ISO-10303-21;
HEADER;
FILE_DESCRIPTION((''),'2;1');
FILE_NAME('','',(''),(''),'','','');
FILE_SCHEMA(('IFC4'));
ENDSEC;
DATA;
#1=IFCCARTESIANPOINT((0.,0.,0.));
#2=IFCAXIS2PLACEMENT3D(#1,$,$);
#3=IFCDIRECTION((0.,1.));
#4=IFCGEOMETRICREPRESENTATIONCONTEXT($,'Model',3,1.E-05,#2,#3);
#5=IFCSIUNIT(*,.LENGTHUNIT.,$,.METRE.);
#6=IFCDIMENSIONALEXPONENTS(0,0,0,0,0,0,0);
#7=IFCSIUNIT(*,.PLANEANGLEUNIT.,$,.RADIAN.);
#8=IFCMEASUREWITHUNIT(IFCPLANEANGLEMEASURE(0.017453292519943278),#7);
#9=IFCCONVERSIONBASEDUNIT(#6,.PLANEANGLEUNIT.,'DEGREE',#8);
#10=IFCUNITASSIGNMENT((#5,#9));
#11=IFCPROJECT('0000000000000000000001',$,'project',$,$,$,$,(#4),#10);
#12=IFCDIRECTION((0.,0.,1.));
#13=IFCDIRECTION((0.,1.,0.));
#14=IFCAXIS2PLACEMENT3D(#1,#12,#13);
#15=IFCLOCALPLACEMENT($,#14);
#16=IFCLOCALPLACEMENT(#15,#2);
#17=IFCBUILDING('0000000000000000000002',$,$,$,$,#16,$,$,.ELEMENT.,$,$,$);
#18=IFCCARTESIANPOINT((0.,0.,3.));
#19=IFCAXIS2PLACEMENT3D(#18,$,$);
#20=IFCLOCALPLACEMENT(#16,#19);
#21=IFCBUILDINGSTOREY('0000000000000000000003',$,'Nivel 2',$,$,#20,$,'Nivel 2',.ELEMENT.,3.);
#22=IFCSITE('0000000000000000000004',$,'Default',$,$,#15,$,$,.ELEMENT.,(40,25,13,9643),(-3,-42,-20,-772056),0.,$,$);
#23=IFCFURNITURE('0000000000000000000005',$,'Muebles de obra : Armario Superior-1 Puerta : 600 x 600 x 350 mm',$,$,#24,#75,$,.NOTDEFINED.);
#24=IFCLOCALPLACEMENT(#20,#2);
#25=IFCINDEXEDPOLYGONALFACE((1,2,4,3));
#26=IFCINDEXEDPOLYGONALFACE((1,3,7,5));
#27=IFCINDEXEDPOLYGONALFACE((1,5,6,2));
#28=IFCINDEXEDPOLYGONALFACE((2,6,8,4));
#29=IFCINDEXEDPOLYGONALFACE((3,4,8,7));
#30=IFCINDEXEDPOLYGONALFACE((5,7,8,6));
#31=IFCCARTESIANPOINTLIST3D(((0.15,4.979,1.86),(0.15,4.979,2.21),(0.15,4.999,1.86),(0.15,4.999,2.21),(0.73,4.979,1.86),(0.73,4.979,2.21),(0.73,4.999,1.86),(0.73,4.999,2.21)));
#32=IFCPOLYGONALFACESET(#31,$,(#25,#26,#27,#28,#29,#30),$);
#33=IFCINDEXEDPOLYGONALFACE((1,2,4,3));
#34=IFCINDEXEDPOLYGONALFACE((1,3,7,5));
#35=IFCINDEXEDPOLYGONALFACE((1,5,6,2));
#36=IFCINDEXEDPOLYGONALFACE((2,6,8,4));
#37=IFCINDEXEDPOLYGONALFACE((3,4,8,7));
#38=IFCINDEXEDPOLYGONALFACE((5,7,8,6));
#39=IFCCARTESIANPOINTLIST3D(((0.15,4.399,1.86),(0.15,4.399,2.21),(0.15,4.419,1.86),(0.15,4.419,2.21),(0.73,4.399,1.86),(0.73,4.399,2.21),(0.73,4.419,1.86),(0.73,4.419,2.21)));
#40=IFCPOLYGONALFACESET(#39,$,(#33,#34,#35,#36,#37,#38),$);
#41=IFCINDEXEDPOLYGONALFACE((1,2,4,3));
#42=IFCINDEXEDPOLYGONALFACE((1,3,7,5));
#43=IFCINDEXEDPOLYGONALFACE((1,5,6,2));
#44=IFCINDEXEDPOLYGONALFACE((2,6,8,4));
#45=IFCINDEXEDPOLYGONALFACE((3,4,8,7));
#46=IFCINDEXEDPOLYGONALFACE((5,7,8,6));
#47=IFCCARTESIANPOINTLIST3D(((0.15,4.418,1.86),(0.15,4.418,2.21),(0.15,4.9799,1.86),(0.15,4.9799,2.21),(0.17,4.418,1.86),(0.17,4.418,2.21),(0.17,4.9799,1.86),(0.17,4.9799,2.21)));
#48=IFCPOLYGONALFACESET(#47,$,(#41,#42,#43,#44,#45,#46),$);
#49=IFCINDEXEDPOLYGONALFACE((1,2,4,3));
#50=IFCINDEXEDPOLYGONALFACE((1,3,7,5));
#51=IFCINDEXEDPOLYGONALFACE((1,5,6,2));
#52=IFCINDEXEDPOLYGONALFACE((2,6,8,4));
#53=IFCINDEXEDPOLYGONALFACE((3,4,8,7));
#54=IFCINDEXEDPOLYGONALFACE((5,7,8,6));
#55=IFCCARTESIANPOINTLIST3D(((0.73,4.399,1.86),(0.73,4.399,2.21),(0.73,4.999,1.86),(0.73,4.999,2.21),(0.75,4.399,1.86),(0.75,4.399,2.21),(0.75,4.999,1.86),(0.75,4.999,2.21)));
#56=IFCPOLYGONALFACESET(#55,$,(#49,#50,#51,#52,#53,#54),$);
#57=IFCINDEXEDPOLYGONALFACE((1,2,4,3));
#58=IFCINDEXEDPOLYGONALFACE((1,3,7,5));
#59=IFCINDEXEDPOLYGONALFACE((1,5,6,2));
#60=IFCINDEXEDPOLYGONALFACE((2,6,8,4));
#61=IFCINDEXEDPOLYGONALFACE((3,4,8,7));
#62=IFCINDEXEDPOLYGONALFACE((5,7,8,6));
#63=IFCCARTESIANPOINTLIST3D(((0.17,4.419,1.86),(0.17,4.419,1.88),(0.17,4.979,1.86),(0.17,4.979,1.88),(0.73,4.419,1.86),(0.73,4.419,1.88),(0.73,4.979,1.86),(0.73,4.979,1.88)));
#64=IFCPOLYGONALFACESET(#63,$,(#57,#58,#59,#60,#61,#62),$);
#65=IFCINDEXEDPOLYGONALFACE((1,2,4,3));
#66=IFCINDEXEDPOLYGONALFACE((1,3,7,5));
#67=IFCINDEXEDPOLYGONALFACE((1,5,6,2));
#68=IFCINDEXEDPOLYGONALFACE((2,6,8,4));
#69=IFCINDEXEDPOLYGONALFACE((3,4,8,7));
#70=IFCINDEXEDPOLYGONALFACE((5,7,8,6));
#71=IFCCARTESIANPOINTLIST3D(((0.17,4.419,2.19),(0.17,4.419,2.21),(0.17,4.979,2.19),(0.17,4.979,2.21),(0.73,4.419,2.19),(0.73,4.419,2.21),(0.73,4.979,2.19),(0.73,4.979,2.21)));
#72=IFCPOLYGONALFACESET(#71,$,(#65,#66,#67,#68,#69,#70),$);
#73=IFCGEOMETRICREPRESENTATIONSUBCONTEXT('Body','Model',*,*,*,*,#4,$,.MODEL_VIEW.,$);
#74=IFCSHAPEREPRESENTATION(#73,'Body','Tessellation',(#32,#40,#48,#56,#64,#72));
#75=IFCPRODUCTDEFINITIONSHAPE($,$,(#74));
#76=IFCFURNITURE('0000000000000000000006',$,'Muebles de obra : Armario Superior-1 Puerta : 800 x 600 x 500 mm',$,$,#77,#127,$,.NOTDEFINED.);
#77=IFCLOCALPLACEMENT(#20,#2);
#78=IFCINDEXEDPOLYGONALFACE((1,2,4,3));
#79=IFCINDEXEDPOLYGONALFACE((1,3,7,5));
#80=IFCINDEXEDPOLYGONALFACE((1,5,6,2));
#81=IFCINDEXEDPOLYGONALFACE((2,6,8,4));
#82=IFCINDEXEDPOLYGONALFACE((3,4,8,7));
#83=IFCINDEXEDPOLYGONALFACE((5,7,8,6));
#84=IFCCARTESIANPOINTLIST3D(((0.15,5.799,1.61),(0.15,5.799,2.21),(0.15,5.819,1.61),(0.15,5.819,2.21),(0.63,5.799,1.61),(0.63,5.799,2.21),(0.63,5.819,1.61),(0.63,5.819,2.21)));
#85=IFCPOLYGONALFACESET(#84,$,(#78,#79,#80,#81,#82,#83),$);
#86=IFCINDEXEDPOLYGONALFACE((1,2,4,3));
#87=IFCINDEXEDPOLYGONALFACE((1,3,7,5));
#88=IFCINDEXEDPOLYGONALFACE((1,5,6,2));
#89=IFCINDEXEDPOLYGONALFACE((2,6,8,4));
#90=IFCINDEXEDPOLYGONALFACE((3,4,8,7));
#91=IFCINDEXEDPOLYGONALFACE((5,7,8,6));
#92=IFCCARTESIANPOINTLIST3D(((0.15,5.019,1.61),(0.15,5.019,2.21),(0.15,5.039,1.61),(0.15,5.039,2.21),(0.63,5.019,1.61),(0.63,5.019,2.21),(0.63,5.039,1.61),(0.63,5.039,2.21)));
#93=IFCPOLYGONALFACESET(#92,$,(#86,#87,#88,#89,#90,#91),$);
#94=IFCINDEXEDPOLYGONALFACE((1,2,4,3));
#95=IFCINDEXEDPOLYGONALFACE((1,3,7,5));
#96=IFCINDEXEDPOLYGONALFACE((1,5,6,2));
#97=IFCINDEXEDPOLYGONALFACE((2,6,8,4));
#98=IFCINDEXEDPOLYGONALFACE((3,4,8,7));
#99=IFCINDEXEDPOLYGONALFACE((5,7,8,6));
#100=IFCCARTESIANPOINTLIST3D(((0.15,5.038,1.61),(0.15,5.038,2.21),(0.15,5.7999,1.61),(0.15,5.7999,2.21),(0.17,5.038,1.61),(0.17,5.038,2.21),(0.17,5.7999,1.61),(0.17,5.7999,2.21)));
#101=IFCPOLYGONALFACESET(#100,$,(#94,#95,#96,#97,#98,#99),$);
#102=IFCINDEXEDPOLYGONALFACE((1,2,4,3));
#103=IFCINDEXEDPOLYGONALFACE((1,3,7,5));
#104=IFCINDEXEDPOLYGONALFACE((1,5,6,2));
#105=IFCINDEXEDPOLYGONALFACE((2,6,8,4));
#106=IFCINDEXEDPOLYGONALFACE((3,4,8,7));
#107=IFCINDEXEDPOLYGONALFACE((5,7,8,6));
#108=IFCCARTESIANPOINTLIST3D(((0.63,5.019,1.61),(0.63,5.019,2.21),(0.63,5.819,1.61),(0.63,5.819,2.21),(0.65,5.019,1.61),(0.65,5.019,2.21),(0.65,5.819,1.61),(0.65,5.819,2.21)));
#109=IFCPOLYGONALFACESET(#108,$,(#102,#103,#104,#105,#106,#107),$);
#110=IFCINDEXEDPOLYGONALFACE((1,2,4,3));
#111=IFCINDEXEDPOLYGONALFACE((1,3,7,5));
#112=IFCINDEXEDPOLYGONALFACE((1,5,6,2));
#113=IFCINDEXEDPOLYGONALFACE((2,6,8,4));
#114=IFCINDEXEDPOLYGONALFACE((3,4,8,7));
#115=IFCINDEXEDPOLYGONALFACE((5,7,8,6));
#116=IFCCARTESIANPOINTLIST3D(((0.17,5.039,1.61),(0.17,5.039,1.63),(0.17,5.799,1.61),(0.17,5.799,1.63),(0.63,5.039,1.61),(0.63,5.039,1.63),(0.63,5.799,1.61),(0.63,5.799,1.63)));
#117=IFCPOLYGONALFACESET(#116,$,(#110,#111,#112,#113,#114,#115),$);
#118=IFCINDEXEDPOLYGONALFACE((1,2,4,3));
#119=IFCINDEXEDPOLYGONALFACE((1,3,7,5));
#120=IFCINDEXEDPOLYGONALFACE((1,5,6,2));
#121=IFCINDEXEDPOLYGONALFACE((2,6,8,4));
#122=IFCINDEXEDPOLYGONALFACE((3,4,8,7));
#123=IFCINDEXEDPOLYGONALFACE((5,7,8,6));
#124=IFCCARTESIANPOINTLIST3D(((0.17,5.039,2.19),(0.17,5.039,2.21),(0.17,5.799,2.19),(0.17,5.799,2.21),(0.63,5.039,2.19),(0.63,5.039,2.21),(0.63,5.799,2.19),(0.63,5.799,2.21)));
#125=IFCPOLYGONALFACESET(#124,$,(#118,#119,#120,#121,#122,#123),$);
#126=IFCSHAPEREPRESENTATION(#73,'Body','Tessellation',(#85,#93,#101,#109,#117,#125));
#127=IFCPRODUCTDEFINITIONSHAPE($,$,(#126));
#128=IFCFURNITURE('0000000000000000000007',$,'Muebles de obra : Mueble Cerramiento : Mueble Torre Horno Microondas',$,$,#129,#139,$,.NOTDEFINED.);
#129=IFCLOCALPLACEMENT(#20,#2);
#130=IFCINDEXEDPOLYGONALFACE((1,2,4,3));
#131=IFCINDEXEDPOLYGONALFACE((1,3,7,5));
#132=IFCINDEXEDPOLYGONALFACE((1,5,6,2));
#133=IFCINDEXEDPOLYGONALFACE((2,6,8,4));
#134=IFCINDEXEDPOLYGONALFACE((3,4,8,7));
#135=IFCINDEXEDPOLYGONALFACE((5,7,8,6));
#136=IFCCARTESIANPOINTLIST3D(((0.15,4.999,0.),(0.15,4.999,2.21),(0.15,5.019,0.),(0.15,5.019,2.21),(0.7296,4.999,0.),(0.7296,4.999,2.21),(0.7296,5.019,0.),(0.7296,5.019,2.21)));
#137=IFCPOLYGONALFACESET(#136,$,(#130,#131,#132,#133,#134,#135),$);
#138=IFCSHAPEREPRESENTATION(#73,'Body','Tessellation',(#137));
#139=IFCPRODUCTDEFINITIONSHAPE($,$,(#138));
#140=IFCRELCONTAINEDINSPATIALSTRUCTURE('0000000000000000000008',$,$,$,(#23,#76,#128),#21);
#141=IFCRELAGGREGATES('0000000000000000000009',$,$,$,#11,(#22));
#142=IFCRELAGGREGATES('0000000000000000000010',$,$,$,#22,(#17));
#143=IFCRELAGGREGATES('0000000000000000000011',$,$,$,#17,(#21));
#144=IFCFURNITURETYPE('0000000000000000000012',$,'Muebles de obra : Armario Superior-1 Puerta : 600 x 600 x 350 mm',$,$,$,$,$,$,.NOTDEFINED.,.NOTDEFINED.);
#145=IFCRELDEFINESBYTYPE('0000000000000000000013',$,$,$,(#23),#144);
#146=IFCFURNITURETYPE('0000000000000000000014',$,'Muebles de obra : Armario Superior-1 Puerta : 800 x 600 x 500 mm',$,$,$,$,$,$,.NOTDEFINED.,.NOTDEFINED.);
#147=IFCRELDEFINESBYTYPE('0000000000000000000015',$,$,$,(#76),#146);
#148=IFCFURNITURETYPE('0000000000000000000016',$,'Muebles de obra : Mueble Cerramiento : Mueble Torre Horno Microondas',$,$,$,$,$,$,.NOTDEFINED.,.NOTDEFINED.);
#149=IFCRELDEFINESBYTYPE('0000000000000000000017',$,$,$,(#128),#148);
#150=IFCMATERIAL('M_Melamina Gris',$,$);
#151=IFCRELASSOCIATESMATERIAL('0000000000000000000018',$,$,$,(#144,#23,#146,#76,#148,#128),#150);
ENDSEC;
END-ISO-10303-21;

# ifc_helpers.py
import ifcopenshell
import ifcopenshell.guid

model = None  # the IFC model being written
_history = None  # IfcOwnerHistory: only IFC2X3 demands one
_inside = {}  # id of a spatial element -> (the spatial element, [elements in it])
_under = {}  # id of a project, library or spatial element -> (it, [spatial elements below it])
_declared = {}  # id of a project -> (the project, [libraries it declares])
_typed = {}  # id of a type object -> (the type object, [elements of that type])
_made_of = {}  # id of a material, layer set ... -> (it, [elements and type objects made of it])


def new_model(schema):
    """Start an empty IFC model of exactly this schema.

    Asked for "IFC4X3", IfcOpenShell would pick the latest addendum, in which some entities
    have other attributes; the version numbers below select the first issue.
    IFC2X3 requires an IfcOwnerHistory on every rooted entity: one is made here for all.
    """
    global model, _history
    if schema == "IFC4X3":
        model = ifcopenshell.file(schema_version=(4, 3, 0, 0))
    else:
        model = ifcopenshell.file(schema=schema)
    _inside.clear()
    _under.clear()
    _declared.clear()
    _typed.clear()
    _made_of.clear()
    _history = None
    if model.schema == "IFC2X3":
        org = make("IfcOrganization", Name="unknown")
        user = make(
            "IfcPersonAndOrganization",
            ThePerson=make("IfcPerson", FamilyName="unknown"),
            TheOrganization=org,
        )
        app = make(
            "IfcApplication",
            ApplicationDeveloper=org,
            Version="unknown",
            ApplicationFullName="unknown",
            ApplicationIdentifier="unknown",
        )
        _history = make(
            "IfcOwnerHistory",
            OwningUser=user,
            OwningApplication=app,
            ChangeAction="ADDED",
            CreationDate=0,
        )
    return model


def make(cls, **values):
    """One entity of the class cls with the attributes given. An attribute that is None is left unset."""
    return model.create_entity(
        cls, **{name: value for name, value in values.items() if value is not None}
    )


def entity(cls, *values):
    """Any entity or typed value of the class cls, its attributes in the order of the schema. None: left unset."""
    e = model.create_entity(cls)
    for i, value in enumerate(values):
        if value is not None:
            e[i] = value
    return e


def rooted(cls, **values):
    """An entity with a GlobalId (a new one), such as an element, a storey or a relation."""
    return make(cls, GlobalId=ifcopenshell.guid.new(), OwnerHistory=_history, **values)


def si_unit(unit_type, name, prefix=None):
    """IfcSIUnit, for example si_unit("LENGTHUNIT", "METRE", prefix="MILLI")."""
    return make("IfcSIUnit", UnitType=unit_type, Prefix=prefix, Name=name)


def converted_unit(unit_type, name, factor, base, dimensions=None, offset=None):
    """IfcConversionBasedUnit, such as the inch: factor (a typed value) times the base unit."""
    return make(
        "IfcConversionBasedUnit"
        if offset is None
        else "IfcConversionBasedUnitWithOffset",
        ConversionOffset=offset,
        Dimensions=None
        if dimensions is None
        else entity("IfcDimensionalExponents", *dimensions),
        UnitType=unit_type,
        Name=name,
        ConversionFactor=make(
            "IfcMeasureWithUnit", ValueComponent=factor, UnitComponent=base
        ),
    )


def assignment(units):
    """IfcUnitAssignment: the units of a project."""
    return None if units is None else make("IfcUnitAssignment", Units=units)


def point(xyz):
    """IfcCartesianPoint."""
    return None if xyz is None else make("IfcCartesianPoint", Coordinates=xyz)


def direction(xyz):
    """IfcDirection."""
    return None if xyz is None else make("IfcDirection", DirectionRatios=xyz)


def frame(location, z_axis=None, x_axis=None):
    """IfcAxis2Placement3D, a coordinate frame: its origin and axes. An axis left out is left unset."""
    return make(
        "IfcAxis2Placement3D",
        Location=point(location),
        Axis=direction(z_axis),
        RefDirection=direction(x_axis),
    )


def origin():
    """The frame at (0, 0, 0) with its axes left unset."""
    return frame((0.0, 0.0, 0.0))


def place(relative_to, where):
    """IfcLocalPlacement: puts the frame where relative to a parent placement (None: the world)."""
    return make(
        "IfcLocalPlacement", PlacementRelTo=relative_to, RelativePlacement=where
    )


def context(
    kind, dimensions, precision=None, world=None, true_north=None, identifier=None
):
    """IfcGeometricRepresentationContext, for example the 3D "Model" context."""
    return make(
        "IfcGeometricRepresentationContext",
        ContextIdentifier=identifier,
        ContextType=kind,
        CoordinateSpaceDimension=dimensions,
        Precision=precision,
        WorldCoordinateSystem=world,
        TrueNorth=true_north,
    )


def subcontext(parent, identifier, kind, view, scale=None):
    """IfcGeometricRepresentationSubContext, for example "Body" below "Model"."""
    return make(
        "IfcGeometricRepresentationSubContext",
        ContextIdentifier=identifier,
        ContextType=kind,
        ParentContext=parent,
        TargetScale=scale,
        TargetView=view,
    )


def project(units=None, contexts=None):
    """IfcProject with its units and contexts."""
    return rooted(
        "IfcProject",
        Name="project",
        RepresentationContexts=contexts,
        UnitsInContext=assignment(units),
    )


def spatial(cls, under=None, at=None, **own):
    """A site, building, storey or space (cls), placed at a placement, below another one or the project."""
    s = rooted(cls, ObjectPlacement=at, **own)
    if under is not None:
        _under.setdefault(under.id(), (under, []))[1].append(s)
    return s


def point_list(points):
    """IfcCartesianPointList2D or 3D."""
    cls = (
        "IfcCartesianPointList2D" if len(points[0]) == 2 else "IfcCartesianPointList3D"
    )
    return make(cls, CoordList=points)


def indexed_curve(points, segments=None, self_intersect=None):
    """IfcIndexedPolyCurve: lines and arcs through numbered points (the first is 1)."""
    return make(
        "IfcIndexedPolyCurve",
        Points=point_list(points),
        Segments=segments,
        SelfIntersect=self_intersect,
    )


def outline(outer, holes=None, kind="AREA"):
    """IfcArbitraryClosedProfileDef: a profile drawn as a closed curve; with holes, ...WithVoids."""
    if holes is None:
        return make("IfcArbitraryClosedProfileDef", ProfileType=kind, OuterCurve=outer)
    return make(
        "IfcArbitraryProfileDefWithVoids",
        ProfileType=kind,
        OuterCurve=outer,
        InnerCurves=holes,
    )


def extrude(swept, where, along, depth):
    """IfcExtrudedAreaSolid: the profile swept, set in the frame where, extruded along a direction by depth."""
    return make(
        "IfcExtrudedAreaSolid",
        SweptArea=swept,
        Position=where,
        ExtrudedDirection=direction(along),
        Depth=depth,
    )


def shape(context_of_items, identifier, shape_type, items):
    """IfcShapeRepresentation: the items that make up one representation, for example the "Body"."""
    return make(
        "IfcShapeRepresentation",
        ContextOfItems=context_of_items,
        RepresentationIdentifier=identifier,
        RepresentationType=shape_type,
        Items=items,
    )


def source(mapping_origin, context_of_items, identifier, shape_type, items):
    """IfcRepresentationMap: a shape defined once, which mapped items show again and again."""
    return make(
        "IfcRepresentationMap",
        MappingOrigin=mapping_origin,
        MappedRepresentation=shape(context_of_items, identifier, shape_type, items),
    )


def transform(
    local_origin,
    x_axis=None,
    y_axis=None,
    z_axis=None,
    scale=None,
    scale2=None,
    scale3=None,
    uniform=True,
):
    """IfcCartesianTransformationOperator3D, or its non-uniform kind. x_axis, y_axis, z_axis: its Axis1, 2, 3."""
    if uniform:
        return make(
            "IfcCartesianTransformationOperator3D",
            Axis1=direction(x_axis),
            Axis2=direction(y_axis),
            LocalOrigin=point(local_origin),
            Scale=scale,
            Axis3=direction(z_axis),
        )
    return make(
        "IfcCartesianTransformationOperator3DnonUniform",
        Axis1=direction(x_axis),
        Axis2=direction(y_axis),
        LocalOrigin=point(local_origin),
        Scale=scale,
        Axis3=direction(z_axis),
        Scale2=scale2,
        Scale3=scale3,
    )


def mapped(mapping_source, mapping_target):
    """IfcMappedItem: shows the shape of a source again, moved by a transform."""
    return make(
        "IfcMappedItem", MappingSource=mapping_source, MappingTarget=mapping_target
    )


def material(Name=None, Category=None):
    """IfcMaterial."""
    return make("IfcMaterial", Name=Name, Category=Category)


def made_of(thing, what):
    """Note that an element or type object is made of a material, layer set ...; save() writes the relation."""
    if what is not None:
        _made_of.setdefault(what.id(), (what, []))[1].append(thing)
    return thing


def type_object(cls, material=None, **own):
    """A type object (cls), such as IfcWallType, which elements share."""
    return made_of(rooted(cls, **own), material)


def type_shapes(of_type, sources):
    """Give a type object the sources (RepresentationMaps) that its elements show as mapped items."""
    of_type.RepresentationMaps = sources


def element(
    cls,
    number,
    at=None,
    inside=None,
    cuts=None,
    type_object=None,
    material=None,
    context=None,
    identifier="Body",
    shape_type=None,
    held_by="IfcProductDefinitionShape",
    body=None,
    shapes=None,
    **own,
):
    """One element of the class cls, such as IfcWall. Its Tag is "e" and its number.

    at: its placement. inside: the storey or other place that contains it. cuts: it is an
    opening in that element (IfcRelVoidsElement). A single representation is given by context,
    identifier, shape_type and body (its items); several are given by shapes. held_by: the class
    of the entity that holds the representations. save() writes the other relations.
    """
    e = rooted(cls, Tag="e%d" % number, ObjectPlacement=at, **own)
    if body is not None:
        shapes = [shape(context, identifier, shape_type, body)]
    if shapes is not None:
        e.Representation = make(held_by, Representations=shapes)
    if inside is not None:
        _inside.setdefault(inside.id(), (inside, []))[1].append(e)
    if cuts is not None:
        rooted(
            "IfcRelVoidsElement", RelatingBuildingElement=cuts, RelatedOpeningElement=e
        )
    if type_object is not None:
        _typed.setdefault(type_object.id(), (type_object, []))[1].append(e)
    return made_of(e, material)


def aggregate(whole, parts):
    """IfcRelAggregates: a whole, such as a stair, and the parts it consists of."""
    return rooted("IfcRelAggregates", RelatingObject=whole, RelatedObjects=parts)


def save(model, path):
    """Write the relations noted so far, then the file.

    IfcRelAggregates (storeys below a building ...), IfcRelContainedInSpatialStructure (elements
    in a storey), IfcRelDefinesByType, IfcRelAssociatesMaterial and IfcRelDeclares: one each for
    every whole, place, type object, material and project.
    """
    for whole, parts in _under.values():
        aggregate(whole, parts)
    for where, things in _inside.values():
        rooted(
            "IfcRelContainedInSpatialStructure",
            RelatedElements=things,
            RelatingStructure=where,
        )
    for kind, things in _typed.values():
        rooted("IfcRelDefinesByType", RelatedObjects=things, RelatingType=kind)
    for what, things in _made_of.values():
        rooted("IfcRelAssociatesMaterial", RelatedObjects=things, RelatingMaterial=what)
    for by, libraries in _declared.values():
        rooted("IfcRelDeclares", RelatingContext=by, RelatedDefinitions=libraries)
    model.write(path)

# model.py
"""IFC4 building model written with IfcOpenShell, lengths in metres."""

from ifc_helpers import new_model, entity, si_unit, converted_unit, direction, frame, origin, place, context, subcontext, project, spatial, indexed_curve, outline, extrude, source, transform, mapped, material, type_object, type_shapes, element, save


model = new_model("IFC4")

# Units and contexts
model_context = context("Model", 3, precision=1e-05, world=origin(), true_north=direction((0.0, 1.0)))
body_context = subcontext(model_context, "Body", "Model", "MODEL_VIEW")
ifc_project = project(units=[si_unit("LENGTHUNIT", "METRE"), converted_unit("PLANEANGLEUNIT", "DEGREE", entity("IfcPlaneAngleMeasure", 0.017453292519943278), si_unit("PLANEANGLEUNIT", "RADIAN"), dimensions=[0, 0, 0, 0, 0, 0, 0])], contexts=[model_context])

# Site, building, storey
site_placement = place(None, frame((0.0, 0.0, 0.0), z_axis=(0.0, 0.0, 1.0), x_axis=(0.0, 1.0, 0.0)))
site = spatial("IfcSite", under=ifc_project, at=site_placement, Name="Default", CompositionType="ELEMENT", RefLatitude=(40, 25, 13, 9643), RefLongitude=(-3, -42, -20, -772056), RefElevation=0.0)
building_placement = place(site_placement, origin())
building = spatial("IfcBuilding", under=site, at=building_placement, CompositionType="ELEMENT")
storey_placement = place(building_placement, frame((0.0, 0.0, 3.0)))
storey = spatial("IfcBuildingStorey", under=building, at=storey_placement, Name="Nivel 2", LongName="Nivel 2", CompositionType="ELEMENT", Elevation=3.0)

# Furniture
ifc_material_1 = material(Name="M_Melamina Gris")
furniture_type_1 = type_object("IfcFurnitureType", Name="Muebles de obra : Armario Superior-1 Puerta : 600 x 600 x 350 mm", AssemblyPlace="NOTDEFINED", PredefinedType="NOTDEFINED", material=ifc_material_1)
shared_shape_1 = source(origin(), body_context, "Body", "SweptSolid", [
    extrude(outline(indexed_curve([(-0.01, -0.29), (0.01, -0.29), (0.01, 0.29), (-0.01, 0.29), (-0.01, -0.29)], self_intersect=False)), frame((-0.4213, 0.29, 0.0), z_axis=(0.0, 0.0, 1.0), x_axis=(-1.0, 0.0, 0.0)), (0.0, 0.0, 1.0), 0.35),
    extrude(outline(indexed_curve([(-0.29, -0.01), (0.29, -0.01), (0.29, 0.01), (-0.29, 0.01), (-0.29, -0.01)], self_intersect=False)), frame((0.1587, 0.29, 0.0), z_axis=(0.0, 0.0, 1.0), x_axis=(0.0, -1.0, 0.0)), (0.0, 0.0, 1.0), 0.35),
    extrude(outline(indexed_curve([(-0.281, -0.01), (0.281, -0.01), (0.281, 0.01), (-0.281, 0.01), (-0.281, -0.01)], self_intersect=False)), frame((-0.1313, 0.01, 0.0)), (0.0, 0.0, 1.0), 0.35),
    extrude(outline(indexed_curve([(-0.3, -0.01), (0.3, -0.01), (0.3, 0.01), (-0.3, 0.01), (-0.3, -0.01)], self_intersect=False)), frame((-0.1313, 0.59, 0.0)), (0.0, 0.0, 1.0), 0.35),
    extrude(outline(indexed_curve([(-0.28, -0.28), (0.28, -0.28), (0.28, 0.28), (-0.28, 0.28), (-0.28, -0.28)], self_intersect=False)), frame((-0.1313, 0.3, 0.0), z_axis=(0.0, 0.0, 1.0), x_axis=(0.0, 1.0, 0.0)), (0.0, 0.0, 1.0), 0.02),
    extrude(outline(indexed_curve([(-0.28, -0.28), (0.28, -0.28), (0.28, 0.28), (-0.28, 0.28), (-0.28, -0.28)], self_intersect=False)), frame((-0.1313, 0.3, 0.33), z_axis=(0.0, 0.0, 1.0), x_axis=(0.0, 1.0, 0.0)), (0.0, 0.0, 1.0), 0.02),
])
type_shapes(furniture_type_1, [shared_shape_1])
furniture_1_placement = place(storey_placement, frame((0.15, 4.5677, 1.86), z_axis=(0.0, 0.0, 1.0), x_axis=(0.0, -1.0, 0.0)))
element("IfcFurniture", 1, at=furniture_1_placement, inside=storey, type_object=furniture_type_1, material=ifc_material_1, Name="Muebles de obra : Armario Superior-1 Puerta : 600 x 600 x 350 mm", PredefinedType="NOTDEFINED", context=body_context, shape_type="MappedRepresentation", body=[
    mapped(shared_shape_1, transform((0.0, 0.0, 0.0), scale=1.0)),
])
furniture_type_2 = type_object("IfcFurnitureType", Name="Muebles de obra : Armario Superior-1 Puerta : 800 x 600 x 500 mm", AssemblyPlace="NOTDEFINED", PredefinedType="NOTDEFINED", material=ifc_material_1)
shared_shape_2 = source(origin(), body_context, "Body", "SweptSolid", [
    extrude(outline(indexed_curve([(-0.01, -0.24), (0.01, -0.24), (0.01, 0.24), (-0.01, 0.24), (-0.01, -0.24)], self_intersect=False)), frame((-0.4213, 0.24, 0.0), z_axis=(0.0, 0.0, 1.0), x_axis=(-1.0, 0.0, 0.0)), (0.0, 0.0, 1.0), 0.6),
    extrude(outline(indexed_curve([(-0.24, -0.01), (0.24, -0.01), (0.24, 0.01), (-0.24, 0.01), (-0.24, -0.01)], self_intersect=False)), frame((0.3587, 0.24, 0.0), z_axis=(0.0, 0.0, 1.0), x_axis=(0.0, -1.0, 0.0)), (0.0, 0.0, 1.0), 0.6),
    extrude(outline(indexed_curve([(-0.381, -0.01), (0.381, -0.01), (0.381, 0.01), (-0.381, 0.01), (-0.381, -0.01)], self_intersect=False)), frame((-0.0313, 0.01, 0.0)), (0.0, 0.0, 1.0), 0.6),
    extrude(outline(indexed_curve([(-0.4, -0.01), (0.4, -0.01), (0.4, 0.01), (-0.4, 0.01), (-0.4, -0.01)], self_intersect=False)), frame((-0.0313, 0.49, 0.0)), (0.0, 0.0, 1.0), 0.6),
    extrude(outline(indexed_curve([(-0.23, -0.38), (0.23, -0.38), (0.23, 0.38), (-0.23, 0.38), (-0.23, -0.38)], self_intersect=False)), frame((-0.0313, 0.25, 0.0), z_axis=(0.0, 0.0, 1.0), x_axis=(0.0, 1.0, 0.0)), (0.0, 0.0, 1.0), 0.02),
    extrude(outline(indexed_curve([(-0.23, -0.38), (0.23, -0.38), (0.23, 0.38), (-0.23, 0.38), (-0.23, -0.38)], self_intersect=False)), frame((-0.0313, 0.25, 0.58), z_axis=(0.0, 0.0, 1.0), x_axis=(0.0, 1.0, 0.0)), (0.0, 0.0, 1.0), 0.02),
])
type_shapes(furniture_type_2, [shared_shape_2])
furniture_2_placement = place(storey_placement, frame((0.15, 5.3877, 1.61), z_axis=(0.0, 0.0, 1.0), x_axis=(0.0, -1.0, 0.0)))
element("IfcFurniture", 2, at=furniture_2_placement, inside=storey, type_object=furniture_type_2, material=ifc_material_1, Name="Muebles de obra : Armario Superior-1 Puerta : 800 x 600 x 500 mm", PredefinedType="NOTDEFINED", context=body_context, shape_type="MappedRepresentation", body=[
    mapped(shared_shape_2, transform((0.0, 0.0, 0.0), scale=1.0)),
])
furniture_type_3 = type_object("IfcFurnitureType", Name="Muebles de obra : Mueble Cerramiento : Mueble Torre Horno Microondas", AssemblyPlace="NOTDEFINED", PredefinedType="NOTDEFINED", material=ifc_material_1)
shared_shape_3 = source(origin(), body_context, "Body", "SweptSolid", [
    extrude(outline(indexed_curve([(-0.2898, -0.01), (0.2898, -0.01), (0.2898, 0.01), (-0.2898, 0.01), (-0.2898, -0.01)], self_intersect=False)), frame((0.0187, -0.2898, 0.0), z_axis=(0.0, 0.0, 1.0), x_axis=(0.0, 1.0, 0.0)), (0.0, 0.0, 1.0), 2.21),
])
type_shapes(furniture_type_3, [shared_shape_3])
furniture_3_placement = place(storey_placement, frame((0.15, 4.9903, 0.0), z_axis=(0.0, 0.0, 1.0), x_axis=(0.0, 1.0, 0.0)))
element("IfcFurniture", 3, at=furniture_3_placement, inside=storey, type_object=furniture_type_3, material=ifc_material_1, Name="Muebles de obra : Mueble Cerramiento : Mueble Torre Horno Microondas", PredefinedType="NOTDEFINED", context=body_context, shape_type="MappedRepresentation", body=[
    mapped(shared_shape_3, transform((0.0, 0.0, 0.0), scale=1.0)),
])

save(model, "model.ifc")
